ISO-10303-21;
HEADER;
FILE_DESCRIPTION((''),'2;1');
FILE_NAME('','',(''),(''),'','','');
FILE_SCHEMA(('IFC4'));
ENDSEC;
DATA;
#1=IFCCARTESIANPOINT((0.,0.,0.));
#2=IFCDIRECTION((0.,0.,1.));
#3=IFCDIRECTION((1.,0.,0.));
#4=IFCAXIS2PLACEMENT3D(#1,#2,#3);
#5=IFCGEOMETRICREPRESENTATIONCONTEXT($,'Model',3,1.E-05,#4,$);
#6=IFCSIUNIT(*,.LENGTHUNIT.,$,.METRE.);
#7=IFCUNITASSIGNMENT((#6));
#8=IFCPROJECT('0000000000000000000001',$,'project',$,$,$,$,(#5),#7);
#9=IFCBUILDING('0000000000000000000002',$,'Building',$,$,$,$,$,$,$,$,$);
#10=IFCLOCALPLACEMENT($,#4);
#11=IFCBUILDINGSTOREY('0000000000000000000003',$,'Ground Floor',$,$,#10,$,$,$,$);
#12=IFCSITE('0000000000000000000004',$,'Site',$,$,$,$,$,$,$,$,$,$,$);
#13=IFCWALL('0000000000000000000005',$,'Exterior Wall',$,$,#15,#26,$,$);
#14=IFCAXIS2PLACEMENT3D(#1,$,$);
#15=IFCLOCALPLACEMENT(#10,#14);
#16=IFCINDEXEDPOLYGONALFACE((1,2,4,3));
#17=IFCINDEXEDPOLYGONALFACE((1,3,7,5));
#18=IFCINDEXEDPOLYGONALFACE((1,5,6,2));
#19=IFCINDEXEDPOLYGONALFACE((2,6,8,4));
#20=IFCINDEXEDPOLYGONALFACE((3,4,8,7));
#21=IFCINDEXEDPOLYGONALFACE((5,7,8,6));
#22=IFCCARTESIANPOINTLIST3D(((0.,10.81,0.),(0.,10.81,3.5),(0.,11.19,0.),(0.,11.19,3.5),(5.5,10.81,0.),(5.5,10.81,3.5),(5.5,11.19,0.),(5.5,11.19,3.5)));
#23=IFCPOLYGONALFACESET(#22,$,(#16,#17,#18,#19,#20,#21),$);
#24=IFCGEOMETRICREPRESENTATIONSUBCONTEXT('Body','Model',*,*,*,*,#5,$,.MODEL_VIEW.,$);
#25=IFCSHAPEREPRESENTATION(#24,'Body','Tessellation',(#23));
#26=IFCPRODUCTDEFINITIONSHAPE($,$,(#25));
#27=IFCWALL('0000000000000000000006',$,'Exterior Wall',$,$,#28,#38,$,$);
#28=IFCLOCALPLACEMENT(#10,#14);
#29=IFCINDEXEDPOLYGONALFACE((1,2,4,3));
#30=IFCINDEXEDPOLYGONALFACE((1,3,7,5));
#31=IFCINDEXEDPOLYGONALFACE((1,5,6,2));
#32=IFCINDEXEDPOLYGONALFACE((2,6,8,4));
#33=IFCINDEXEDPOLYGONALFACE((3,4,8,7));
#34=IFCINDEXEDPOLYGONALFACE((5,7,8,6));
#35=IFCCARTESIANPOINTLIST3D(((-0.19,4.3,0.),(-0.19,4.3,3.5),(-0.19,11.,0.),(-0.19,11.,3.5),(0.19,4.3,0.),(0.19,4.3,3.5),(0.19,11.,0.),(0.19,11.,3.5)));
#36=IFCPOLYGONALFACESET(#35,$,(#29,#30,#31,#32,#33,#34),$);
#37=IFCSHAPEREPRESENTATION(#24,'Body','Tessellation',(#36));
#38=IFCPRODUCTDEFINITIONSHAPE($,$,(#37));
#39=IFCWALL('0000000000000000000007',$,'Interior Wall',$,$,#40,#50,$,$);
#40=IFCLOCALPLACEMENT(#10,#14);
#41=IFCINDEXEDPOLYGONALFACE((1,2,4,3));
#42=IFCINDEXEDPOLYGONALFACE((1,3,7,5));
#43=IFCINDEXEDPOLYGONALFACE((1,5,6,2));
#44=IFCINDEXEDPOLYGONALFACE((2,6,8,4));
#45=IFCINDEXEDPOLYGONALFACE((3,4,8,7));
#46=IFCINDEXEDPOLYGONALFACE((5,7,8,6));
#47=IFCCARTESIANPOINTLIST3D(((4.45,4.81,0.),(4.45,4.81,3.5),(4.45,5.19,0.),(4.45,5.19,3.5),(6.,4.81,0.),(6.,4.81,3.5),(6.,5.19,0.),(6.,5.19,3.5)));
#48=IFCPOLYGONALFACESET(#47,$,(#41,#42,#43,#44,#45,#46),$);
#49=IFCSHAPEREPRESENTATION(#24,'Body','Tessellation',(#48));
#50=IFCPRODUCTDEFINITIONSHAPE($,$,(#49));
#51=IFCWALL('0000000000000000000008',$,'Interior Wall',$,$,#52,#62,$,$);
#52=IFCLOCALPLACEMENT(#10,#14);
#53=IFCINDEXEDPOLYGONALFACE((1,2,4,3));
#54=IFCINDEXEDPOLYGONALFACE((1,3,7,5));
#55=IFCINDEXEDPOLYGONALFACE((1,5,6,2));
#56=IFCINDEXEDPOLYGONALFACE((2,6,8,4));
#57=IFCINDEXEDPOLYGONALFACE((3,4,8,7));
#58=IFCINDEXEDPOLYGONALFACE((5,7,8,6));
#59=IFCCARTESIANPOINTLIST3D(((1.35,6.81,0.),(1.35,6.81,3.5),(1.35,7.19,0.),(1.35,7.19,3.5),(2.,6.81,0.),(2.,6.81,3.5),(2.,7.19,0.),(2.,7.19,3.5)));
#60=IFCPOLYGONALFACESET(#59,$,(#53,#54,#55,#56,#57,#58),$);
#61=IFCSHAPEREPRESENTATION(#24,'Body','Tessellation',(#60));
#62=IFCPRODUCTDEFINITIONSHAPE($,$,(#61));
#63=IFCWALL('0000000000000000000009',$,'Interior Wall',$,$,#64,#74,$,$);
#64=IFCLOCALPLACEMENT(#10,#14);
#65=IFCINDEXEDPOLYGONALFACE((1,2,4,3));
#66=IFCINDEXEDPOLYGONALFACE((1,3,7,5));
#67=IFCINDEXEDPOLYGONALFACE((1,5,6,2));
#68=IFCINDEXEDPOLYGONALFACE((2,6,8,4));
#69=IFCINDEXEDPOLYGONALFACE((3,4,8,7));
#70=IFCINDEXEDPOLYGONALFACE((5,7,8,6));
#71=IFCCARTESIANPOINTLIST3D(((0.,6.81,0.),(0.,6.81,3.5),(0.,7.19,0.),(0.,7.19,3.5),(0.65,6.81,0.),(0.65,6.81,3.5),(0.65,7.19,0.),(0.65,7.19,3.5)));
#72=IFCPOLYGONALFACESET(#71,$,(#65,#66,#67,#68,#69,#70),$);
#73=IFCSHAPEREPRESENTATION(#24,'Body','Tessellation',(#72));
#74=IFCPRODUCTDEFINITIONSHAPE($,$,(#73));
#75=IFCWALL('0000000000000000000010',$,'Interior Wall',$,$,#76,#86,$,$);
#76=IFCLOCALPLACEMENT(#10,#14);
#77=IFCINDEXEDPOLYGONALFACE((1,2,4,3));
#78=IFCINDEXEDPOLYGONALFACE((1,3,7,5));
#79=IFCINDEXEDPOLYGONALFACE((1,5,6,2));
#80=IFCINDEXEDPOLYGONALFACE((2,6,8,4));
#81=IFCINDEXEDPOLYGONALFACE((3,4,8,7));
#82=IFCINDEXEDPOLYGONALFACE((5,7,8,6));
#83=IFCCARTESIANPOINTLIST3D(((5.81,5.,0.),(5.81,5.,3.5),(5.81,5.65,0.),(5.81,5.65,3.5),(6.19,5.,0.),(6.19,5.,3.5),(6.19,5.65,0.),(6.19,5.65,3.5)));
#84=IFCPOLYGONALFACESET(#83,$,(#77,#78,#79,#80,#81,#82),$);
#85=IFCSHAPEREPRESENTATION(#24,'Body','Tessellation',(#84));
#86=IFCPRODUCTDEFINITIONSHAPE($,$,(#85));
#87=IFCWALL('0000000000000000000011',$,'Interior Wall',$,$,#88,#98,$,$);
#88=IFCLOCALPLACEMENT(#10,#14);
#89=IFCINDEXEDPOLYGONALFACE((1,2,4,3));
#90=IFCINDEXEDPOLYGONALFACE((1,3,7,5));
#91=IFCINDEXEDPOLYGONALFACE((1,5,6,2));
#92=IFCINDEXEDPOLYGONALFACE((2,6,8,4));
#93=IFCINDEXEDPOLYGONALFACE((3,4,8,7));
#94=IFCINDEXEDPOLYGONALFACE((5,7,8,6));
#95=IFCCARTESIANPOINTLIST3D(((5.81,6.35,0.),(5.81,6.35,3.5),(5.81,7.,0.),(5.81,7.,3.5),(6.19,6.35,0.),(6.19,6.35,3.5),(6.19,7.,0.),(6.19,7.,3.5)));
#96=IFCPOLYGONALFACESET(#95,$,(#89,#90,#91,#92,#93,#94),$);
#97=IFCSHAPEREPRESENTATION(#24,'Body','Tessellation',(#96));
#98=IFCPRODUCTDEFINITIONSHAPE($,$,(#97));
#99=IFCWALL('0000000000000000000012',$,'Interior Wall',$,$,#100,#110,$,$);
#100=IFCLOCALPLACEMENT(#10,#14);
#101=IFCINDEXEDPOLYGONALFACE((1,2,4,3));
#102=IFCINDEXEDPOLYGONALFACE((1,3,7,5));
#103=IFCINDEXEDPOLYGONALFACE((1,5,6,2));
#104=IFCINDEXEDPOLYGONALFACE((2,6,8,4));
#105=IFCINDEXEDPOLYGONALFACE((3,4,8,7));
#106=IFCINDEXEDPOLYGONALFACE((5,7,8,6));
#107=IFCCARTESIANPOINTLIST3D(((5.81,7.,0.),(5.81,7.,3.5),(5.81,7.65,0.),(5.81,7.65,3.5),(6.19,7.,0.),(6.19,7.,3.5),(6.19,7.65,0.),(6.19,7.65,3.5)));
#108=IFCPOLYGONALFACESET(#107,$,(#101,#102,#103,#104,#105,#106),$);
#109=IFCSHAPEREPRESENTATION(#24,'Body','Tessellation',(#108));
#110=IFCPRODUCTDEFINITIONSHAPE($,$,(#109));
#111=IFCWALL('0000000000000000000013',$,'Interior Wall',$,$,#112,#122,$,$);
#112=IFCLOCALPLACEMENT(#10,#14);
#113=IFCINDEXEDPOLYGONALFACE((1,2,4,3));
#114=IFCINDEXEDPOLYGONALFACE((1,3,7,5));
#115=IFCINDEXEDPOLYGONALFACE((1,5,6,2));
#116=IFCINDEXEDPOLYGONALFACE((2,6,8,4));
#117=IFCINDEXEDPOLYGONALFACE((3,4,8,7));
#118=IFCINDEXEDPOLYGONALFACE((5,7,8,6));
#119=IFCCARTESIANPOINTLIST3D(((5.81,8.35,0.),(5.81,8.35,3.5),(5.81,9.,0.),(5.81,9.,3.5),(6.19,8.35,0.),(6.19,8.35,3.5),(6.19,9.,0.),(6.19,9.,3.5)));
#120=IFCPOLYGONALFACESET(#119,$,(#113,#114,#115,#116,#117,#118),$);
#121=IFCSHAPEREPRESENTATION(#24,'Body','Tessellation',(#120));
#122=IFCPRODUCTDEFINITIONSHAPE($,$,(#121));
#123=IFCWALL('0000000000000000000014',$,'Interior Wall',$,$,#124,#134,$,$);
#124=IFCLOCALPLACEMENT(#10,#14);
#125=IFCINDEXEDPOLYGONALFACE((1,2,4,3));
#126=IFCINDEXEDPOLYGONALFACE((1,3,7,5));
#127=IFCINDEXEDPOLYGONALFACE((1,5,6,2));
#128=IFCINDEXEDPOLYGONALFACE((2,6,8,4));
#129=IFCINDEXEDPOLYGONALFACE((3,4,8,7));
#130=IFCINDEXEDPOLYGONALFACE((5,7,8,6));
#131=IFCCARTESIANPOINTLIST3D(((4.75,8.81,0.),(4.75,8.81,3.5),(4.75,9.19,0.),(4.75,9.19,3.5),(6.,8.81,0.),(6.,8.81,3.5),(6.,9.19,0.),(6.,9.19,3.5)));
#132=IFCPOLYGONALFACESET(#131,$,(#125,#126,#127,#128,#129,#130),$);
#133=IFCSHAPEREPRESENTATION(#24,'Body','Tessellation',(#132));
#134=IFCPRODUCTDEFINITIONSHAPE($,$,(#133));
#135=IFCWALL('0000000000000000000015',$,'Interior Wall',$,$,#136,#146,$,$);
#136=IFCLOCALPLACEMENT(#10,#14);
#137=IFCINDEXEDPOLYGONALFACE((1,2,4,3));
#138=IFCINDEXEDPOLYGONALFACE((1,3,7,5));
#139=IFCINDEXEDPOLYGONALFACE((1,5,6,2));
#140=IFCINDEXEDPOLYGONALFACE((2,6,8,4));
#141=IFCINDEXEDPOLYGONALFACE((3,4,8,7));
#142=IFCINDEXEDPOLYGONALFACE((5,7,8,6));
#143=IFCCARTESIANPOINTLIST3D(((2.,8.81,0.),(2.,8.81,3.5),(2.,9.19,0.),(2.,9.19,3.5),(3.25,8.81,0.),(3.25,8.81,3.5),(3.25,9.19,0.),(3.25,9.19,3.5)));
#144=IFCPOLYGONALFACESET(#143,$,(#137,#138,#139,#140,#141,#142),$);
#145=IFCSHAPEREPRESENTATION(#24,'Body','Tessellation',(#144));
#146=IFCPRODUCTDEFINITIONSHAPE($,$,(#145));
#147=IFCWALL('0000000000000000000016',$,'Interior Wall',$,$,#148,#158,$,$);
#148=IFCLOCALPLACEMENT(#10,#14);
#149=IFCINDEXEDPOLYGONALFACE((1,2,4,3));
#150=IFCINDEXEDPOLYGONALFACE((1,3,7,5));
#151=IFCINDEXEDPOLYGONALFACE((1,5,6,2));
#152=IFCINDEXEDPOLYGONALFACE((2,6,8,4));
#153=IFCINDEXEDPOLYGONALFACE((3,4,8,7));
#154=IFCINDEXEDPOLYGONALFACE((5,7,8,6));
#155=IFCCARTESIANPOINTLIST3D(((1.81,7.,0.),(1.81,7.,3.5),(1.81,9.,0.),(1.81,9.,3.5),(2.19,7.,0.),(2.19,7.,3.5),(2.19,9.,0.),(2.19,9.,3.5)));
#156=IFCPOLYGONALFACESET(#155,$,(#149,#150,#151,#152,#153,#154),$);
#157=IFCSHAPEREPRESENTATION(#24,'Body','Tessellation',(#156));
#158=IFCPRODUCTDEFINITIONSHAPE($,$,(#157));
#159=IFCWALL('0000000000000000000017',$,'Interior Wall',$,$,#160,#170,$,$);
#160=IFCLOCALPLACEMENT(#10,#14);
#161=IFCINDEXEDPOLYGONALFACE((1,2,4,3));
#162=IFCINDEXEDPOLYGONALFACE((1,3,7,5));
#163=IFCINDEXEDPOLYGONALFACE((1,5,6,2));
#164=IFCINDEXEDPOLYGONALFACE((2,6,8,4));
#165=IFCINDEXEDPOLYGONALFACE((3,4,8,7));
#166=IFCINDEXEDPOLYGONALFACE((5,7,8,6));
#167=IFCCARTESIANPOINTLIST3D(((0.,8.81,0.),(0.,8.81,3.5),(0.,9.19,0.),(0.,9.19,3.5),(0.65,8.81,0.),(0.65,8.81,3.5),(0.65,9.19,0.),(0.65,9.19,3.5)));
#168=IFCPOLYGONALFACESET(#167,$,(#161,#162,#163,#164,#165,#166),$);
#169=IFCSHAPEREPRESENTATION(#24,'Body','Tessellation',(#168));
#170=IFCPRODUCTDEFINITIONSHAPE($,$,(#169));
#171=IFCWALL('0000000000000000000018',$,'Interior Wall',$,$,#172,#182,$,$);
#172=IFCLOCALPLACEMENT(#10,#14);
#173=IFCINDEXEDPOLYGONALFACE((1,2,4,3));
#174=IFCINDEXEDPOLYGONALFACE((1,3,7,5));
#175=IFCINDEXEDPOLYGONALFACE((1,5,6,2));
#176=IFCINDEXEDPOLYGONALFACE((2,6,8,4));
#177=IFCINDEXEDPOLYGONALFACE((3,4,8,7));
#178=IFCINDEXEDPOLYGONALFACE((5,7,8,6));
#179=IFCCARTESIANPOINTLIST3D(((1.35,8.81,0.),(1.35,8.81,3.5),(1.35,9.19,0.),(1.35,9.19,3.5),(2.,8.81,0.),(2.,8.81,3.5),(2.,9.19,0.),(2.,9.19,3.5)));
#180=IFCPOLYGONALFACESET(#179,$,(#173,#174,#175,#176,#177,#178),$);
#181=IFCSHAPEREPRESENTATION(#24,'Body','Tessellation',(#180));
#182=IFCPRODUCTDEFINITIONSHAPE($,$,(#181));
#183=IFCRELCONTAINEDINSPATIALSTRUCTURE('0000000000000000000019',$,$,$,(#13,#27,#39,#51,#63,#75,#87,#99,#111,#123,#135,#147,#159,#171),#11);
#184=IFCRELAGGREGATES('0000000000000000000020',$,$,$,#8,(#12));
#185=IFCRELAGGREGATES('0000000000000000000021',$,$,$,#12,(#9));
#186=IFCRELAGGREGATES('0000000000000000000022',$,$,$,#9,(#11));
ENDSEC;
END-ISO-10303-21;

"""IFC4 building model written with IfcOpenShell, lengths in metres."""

from ifc_helpers import new_model, si_unit, frame, origin_with_axes, place, context, subcontext, project, spatial, indexed_curve, outline, extrude, element, save


model = new_model("IFC4")

# Units and contexts
model_context = context("Model", 3, precision=1e-05, world=origin_with_axes())
body_context = subcontext(model_context, "Body", "Model", "MODEL_VIEW")
ifc_project = project(units=[si_unit("LENGTHUNIT", "METRE")], contexts=[model_context])

# Site, building, storey
site = spatial("IfcSite", under=ifc_project, Name="Site")
building = spatial("IfcBuilding", under=site, Name="Building")
storey_placement = place(None, origin_with_axes())
storey = spatial("IfcBuildingStorey", under=building, at=storey_placement, Name="Ground Floor")

# Walls
wall_1_placement = place(storey_placement, frame((5.5, 11.0, 0.0), z_axis=(0.0, 0.0, 1.0), x_axis=(-1.0, 0.0, 0.0)))
element("IfcWall", 1, at=wall_1_placement, inside=storey, Name="Exterior Wall", context=body_context, shape_type="SweptSolid", body=[
    extrude(outline(indexed_curve([(0.0, 0.0), (0.0, 0.38), (5.5, 0.38), (5.5, 0.0), (0.0, 0.0)], self_intersect=False)), frame((0.0, -0.19, 0.0), z_axis=(0.0, 0.0, 1.0), x_axis=(1.0, 0.0, 0.0)), (0.0, 0.0, 1.0), 3.5),
])
wall_2_placement = place(storey_placement, frame((0.0, 11.0, 0.0), z_axis=(0.0, 0.0, 1.0), x_axis=(0.0, -1.0, 0.0)))
element("IfcWall", 2, at=wall_2_placement, inside=storey, Name="Exterior Wall", context=body_context, shape_type="SweptSolid", body=[
    extrude(outline(indexed_curve([(0.0, 0.0), (0.0, 0.38), (6.7, 0.38), (6.7, 0.0), (0.0, 0.0)], self_intersect=False)), frame((0.0, -0.19, 0.0), z_axis=(0.0, 0.0, 1.0), x_axis=(1.0, 0.0, 0.0)), (0.0, 0.0, 1.0), 3.5),
])
wall_3_placement = place(storey_placement, frame((6.0, 5.0, 0.0), z_axis=(0.0, 0.0, 1.0), x_axis=(-1.0, 0.0, 0.0)))
element("IfcWall", 3, at=wall_3_placement, inside=storey, Name="Interior Wall", context=body_context, shape_type="SweptSolid", body=[
    extrude(outline(indexed_curve([(0.0, 0.0), (0.0, 0.38), (1.55, 0.38), (1.55, 0.0), (0.0, 0.0)], self_intersect=False)), frame((0.0, -0.19, 0.0), z_axis=(0.0, 0.0, 1.0), x_axis=(1.0, 0.0, 0.0)), (0.0, 0.0, 1.0), 3.5),
])
for number, where, z_axis, x_axis, name in (
    (4, (2.0, 7.0, 0.0), (0.0, 0.0, 1.0), (-1.0, 0.0, 0.0), "Interior Wall"),
    (5, (0.65, 7.0, 0.0), (0.0, 0.0, 1.0), (-1.0, 0.0, 0.0), "Interior Wall"),
):
    element("IfcWall", number, at=place(storey_placement, frame(where, z_axis=z_axis, x_axis=x_axis)), inside=storey, Name=name, context=body_context, shape_type="SweptSolid", body=[
        extrude(outline(indexed_curve([(0.0, 0.0), (0.0, 0.38), (0.65, 0.38), (0.65, 0.0), (0.0, 0.0)], self_intersect=False)), frame((0.0, -0.19, 0.0), z_axis=(0.0, 0.0, 1.0), x_axis=(1.0, 0.0, 0.0)), (0.0, 0.0, 1.0), 3.5),
    ])
for number, where, z_axis, x_axis, name in (
    (6, (6.0, 5.0, 0.0), (0.0, 0.0, 1.0), (0.0, 1.0, 0.0), "Interior Wall"),
    (7, (6.0, 6.35, 0.0), (0.0, 0.0, 1.0), (0.0, 1.0, 0.0), "Interior Wall"),
    (8, (6.0, 7.0, 0.0), (0.0, 0.0, 1.0), (0.0, 1.0, 0.0), "Interior Wall"),
    (9, (6.0, 8.35, 0.0), (0.0, 0.0, 1.0), (0.0, 1.0, 0.0), "Interior Wall"),
):
    element("IfcWall", number, at=place(storey_placement, frame(where, z_axis=z_axis, x_axis=x_axis)), inside=storey, Name=name, context=body_context, shape_type="SweptSolid", body=[
        extrude(outline(indexed_curve([(0.0, 0.0), (0.0, 0.38), (0.65, 0.38), (0.65, 0.0), (0.0, 0.0)], self_intersect=False)), frame((0.0, -0.19, 0.0), z_axis=(0.0, 0.0, 1.0), x_axis=(1.0, 0.0, 0.0)), (0.0, 0.0, 1.0), 3.5),
    ])
for number, where, z_axis, x_axis, name in (
    (10, (6.0, 9.0, 0.0), (0.0, 0.0, 1.0), (-1.0, 0.0, 0.0), "Interior Wall"),
    (11, (3.25, 9.0, 0.0), (0.0, 0.0, 1.0), (-1.0, 0.0, 0.0), "Interior Wall"),
):
    element("IfcWall", number, at=place(storey_placement, frame(where, z_axis=z_axis, x_axis=x_axis)), inside=storey, Name=name, context=body_context, shape_type="SweptSolid", body=[
        extrude(outline(indexed_curve([(0.0, 0.0), (0.0, 0.38), (1.25, 0.38), (1.25, 0.0), (0.0, 0.0)], self_intersect=False)), frame((0.0, -0.19, 0.0), z_axis=(0.0, 0.0, 1.0), x_axis=(1.0, 0.0, 0.0)), (0.0, 0.0, 1.0), 3.5),
    ])
wall_4_placement = place(storey_placement, frame((2.0, 9.0, 0.0), z_axis=(0.0, 0.0, 1.0), x_axis=(0.0, -1.0, 0.0)))
element("IfcWall", 12, at=wall_4_placement, inside=storey, Name="Interior Wall", context=body_context, shape_type="SweptSolid", body=[
    extrude(outline(indexed_curve([(0.0, 0.0), (0.0, 0.38), (2.0, 0.38), (2.0, 0.0), (0.0, 0.0)], self_intersect=False)), frame((0.0, -0.19, 0.0), z_axis=(0.0, 0.0, 1.0), x_axis=(1.0, 0.0, 0.0)), (0.0, 0.0, 1.0), 3.5),
])
wall_5_placement = place(storey_placement, frame((0.0, 9.0, 0.0), z_axis=(0.0, 0.0, 1.0), x_axis=(1.0, 0.0, 0.0)))
element("IfcWall", 13, at=wall_5_placement, inside=storey, Name="Interior Wall", context=body_context, shape_type="SweptSolid", body=[
    extrude(outline(indexed_curve([(0.0, 0.0), (0.0, 0.38), (0.65, 0.38), (0.65, 0.0), (0.0, 0.0)], self_intersect=False)), frame((0.0, -0.19, 0.0), z_axis=(0.0, 0.0, 1.0), x_axis=(1.0, 0.0, 0.0)), (0.0, 0.0, 1.0), 3.5),
])
wall_6_placement = place(storey_placement, frame((1.35, 9.0, 0.0), z_axis=(0.0, 0.0, 1.0), x_axis=(1.0, 0.0, 0.0)))
element("IfcWall", 14, at=wall_6_placement, inside=storey, Name="Interior Wall", context=body_context, shape_type="SweptSolid", body=[
    extrude(outline(indexed_curve([(0.0, 0.0), (0.0, 0.38), (0.65, 0.38), (0.65, 0.0), (0.0, 0.0)], self_intersect=False)), frame((0.0, -0.19, 0.0), z_axis=(0.0, 0.0, 1.0), x_axis=(1.0, 0.0, 0.0)), (0.0, 0.0, 1.0), 3.5),
])

save(model, "model.ifc")
